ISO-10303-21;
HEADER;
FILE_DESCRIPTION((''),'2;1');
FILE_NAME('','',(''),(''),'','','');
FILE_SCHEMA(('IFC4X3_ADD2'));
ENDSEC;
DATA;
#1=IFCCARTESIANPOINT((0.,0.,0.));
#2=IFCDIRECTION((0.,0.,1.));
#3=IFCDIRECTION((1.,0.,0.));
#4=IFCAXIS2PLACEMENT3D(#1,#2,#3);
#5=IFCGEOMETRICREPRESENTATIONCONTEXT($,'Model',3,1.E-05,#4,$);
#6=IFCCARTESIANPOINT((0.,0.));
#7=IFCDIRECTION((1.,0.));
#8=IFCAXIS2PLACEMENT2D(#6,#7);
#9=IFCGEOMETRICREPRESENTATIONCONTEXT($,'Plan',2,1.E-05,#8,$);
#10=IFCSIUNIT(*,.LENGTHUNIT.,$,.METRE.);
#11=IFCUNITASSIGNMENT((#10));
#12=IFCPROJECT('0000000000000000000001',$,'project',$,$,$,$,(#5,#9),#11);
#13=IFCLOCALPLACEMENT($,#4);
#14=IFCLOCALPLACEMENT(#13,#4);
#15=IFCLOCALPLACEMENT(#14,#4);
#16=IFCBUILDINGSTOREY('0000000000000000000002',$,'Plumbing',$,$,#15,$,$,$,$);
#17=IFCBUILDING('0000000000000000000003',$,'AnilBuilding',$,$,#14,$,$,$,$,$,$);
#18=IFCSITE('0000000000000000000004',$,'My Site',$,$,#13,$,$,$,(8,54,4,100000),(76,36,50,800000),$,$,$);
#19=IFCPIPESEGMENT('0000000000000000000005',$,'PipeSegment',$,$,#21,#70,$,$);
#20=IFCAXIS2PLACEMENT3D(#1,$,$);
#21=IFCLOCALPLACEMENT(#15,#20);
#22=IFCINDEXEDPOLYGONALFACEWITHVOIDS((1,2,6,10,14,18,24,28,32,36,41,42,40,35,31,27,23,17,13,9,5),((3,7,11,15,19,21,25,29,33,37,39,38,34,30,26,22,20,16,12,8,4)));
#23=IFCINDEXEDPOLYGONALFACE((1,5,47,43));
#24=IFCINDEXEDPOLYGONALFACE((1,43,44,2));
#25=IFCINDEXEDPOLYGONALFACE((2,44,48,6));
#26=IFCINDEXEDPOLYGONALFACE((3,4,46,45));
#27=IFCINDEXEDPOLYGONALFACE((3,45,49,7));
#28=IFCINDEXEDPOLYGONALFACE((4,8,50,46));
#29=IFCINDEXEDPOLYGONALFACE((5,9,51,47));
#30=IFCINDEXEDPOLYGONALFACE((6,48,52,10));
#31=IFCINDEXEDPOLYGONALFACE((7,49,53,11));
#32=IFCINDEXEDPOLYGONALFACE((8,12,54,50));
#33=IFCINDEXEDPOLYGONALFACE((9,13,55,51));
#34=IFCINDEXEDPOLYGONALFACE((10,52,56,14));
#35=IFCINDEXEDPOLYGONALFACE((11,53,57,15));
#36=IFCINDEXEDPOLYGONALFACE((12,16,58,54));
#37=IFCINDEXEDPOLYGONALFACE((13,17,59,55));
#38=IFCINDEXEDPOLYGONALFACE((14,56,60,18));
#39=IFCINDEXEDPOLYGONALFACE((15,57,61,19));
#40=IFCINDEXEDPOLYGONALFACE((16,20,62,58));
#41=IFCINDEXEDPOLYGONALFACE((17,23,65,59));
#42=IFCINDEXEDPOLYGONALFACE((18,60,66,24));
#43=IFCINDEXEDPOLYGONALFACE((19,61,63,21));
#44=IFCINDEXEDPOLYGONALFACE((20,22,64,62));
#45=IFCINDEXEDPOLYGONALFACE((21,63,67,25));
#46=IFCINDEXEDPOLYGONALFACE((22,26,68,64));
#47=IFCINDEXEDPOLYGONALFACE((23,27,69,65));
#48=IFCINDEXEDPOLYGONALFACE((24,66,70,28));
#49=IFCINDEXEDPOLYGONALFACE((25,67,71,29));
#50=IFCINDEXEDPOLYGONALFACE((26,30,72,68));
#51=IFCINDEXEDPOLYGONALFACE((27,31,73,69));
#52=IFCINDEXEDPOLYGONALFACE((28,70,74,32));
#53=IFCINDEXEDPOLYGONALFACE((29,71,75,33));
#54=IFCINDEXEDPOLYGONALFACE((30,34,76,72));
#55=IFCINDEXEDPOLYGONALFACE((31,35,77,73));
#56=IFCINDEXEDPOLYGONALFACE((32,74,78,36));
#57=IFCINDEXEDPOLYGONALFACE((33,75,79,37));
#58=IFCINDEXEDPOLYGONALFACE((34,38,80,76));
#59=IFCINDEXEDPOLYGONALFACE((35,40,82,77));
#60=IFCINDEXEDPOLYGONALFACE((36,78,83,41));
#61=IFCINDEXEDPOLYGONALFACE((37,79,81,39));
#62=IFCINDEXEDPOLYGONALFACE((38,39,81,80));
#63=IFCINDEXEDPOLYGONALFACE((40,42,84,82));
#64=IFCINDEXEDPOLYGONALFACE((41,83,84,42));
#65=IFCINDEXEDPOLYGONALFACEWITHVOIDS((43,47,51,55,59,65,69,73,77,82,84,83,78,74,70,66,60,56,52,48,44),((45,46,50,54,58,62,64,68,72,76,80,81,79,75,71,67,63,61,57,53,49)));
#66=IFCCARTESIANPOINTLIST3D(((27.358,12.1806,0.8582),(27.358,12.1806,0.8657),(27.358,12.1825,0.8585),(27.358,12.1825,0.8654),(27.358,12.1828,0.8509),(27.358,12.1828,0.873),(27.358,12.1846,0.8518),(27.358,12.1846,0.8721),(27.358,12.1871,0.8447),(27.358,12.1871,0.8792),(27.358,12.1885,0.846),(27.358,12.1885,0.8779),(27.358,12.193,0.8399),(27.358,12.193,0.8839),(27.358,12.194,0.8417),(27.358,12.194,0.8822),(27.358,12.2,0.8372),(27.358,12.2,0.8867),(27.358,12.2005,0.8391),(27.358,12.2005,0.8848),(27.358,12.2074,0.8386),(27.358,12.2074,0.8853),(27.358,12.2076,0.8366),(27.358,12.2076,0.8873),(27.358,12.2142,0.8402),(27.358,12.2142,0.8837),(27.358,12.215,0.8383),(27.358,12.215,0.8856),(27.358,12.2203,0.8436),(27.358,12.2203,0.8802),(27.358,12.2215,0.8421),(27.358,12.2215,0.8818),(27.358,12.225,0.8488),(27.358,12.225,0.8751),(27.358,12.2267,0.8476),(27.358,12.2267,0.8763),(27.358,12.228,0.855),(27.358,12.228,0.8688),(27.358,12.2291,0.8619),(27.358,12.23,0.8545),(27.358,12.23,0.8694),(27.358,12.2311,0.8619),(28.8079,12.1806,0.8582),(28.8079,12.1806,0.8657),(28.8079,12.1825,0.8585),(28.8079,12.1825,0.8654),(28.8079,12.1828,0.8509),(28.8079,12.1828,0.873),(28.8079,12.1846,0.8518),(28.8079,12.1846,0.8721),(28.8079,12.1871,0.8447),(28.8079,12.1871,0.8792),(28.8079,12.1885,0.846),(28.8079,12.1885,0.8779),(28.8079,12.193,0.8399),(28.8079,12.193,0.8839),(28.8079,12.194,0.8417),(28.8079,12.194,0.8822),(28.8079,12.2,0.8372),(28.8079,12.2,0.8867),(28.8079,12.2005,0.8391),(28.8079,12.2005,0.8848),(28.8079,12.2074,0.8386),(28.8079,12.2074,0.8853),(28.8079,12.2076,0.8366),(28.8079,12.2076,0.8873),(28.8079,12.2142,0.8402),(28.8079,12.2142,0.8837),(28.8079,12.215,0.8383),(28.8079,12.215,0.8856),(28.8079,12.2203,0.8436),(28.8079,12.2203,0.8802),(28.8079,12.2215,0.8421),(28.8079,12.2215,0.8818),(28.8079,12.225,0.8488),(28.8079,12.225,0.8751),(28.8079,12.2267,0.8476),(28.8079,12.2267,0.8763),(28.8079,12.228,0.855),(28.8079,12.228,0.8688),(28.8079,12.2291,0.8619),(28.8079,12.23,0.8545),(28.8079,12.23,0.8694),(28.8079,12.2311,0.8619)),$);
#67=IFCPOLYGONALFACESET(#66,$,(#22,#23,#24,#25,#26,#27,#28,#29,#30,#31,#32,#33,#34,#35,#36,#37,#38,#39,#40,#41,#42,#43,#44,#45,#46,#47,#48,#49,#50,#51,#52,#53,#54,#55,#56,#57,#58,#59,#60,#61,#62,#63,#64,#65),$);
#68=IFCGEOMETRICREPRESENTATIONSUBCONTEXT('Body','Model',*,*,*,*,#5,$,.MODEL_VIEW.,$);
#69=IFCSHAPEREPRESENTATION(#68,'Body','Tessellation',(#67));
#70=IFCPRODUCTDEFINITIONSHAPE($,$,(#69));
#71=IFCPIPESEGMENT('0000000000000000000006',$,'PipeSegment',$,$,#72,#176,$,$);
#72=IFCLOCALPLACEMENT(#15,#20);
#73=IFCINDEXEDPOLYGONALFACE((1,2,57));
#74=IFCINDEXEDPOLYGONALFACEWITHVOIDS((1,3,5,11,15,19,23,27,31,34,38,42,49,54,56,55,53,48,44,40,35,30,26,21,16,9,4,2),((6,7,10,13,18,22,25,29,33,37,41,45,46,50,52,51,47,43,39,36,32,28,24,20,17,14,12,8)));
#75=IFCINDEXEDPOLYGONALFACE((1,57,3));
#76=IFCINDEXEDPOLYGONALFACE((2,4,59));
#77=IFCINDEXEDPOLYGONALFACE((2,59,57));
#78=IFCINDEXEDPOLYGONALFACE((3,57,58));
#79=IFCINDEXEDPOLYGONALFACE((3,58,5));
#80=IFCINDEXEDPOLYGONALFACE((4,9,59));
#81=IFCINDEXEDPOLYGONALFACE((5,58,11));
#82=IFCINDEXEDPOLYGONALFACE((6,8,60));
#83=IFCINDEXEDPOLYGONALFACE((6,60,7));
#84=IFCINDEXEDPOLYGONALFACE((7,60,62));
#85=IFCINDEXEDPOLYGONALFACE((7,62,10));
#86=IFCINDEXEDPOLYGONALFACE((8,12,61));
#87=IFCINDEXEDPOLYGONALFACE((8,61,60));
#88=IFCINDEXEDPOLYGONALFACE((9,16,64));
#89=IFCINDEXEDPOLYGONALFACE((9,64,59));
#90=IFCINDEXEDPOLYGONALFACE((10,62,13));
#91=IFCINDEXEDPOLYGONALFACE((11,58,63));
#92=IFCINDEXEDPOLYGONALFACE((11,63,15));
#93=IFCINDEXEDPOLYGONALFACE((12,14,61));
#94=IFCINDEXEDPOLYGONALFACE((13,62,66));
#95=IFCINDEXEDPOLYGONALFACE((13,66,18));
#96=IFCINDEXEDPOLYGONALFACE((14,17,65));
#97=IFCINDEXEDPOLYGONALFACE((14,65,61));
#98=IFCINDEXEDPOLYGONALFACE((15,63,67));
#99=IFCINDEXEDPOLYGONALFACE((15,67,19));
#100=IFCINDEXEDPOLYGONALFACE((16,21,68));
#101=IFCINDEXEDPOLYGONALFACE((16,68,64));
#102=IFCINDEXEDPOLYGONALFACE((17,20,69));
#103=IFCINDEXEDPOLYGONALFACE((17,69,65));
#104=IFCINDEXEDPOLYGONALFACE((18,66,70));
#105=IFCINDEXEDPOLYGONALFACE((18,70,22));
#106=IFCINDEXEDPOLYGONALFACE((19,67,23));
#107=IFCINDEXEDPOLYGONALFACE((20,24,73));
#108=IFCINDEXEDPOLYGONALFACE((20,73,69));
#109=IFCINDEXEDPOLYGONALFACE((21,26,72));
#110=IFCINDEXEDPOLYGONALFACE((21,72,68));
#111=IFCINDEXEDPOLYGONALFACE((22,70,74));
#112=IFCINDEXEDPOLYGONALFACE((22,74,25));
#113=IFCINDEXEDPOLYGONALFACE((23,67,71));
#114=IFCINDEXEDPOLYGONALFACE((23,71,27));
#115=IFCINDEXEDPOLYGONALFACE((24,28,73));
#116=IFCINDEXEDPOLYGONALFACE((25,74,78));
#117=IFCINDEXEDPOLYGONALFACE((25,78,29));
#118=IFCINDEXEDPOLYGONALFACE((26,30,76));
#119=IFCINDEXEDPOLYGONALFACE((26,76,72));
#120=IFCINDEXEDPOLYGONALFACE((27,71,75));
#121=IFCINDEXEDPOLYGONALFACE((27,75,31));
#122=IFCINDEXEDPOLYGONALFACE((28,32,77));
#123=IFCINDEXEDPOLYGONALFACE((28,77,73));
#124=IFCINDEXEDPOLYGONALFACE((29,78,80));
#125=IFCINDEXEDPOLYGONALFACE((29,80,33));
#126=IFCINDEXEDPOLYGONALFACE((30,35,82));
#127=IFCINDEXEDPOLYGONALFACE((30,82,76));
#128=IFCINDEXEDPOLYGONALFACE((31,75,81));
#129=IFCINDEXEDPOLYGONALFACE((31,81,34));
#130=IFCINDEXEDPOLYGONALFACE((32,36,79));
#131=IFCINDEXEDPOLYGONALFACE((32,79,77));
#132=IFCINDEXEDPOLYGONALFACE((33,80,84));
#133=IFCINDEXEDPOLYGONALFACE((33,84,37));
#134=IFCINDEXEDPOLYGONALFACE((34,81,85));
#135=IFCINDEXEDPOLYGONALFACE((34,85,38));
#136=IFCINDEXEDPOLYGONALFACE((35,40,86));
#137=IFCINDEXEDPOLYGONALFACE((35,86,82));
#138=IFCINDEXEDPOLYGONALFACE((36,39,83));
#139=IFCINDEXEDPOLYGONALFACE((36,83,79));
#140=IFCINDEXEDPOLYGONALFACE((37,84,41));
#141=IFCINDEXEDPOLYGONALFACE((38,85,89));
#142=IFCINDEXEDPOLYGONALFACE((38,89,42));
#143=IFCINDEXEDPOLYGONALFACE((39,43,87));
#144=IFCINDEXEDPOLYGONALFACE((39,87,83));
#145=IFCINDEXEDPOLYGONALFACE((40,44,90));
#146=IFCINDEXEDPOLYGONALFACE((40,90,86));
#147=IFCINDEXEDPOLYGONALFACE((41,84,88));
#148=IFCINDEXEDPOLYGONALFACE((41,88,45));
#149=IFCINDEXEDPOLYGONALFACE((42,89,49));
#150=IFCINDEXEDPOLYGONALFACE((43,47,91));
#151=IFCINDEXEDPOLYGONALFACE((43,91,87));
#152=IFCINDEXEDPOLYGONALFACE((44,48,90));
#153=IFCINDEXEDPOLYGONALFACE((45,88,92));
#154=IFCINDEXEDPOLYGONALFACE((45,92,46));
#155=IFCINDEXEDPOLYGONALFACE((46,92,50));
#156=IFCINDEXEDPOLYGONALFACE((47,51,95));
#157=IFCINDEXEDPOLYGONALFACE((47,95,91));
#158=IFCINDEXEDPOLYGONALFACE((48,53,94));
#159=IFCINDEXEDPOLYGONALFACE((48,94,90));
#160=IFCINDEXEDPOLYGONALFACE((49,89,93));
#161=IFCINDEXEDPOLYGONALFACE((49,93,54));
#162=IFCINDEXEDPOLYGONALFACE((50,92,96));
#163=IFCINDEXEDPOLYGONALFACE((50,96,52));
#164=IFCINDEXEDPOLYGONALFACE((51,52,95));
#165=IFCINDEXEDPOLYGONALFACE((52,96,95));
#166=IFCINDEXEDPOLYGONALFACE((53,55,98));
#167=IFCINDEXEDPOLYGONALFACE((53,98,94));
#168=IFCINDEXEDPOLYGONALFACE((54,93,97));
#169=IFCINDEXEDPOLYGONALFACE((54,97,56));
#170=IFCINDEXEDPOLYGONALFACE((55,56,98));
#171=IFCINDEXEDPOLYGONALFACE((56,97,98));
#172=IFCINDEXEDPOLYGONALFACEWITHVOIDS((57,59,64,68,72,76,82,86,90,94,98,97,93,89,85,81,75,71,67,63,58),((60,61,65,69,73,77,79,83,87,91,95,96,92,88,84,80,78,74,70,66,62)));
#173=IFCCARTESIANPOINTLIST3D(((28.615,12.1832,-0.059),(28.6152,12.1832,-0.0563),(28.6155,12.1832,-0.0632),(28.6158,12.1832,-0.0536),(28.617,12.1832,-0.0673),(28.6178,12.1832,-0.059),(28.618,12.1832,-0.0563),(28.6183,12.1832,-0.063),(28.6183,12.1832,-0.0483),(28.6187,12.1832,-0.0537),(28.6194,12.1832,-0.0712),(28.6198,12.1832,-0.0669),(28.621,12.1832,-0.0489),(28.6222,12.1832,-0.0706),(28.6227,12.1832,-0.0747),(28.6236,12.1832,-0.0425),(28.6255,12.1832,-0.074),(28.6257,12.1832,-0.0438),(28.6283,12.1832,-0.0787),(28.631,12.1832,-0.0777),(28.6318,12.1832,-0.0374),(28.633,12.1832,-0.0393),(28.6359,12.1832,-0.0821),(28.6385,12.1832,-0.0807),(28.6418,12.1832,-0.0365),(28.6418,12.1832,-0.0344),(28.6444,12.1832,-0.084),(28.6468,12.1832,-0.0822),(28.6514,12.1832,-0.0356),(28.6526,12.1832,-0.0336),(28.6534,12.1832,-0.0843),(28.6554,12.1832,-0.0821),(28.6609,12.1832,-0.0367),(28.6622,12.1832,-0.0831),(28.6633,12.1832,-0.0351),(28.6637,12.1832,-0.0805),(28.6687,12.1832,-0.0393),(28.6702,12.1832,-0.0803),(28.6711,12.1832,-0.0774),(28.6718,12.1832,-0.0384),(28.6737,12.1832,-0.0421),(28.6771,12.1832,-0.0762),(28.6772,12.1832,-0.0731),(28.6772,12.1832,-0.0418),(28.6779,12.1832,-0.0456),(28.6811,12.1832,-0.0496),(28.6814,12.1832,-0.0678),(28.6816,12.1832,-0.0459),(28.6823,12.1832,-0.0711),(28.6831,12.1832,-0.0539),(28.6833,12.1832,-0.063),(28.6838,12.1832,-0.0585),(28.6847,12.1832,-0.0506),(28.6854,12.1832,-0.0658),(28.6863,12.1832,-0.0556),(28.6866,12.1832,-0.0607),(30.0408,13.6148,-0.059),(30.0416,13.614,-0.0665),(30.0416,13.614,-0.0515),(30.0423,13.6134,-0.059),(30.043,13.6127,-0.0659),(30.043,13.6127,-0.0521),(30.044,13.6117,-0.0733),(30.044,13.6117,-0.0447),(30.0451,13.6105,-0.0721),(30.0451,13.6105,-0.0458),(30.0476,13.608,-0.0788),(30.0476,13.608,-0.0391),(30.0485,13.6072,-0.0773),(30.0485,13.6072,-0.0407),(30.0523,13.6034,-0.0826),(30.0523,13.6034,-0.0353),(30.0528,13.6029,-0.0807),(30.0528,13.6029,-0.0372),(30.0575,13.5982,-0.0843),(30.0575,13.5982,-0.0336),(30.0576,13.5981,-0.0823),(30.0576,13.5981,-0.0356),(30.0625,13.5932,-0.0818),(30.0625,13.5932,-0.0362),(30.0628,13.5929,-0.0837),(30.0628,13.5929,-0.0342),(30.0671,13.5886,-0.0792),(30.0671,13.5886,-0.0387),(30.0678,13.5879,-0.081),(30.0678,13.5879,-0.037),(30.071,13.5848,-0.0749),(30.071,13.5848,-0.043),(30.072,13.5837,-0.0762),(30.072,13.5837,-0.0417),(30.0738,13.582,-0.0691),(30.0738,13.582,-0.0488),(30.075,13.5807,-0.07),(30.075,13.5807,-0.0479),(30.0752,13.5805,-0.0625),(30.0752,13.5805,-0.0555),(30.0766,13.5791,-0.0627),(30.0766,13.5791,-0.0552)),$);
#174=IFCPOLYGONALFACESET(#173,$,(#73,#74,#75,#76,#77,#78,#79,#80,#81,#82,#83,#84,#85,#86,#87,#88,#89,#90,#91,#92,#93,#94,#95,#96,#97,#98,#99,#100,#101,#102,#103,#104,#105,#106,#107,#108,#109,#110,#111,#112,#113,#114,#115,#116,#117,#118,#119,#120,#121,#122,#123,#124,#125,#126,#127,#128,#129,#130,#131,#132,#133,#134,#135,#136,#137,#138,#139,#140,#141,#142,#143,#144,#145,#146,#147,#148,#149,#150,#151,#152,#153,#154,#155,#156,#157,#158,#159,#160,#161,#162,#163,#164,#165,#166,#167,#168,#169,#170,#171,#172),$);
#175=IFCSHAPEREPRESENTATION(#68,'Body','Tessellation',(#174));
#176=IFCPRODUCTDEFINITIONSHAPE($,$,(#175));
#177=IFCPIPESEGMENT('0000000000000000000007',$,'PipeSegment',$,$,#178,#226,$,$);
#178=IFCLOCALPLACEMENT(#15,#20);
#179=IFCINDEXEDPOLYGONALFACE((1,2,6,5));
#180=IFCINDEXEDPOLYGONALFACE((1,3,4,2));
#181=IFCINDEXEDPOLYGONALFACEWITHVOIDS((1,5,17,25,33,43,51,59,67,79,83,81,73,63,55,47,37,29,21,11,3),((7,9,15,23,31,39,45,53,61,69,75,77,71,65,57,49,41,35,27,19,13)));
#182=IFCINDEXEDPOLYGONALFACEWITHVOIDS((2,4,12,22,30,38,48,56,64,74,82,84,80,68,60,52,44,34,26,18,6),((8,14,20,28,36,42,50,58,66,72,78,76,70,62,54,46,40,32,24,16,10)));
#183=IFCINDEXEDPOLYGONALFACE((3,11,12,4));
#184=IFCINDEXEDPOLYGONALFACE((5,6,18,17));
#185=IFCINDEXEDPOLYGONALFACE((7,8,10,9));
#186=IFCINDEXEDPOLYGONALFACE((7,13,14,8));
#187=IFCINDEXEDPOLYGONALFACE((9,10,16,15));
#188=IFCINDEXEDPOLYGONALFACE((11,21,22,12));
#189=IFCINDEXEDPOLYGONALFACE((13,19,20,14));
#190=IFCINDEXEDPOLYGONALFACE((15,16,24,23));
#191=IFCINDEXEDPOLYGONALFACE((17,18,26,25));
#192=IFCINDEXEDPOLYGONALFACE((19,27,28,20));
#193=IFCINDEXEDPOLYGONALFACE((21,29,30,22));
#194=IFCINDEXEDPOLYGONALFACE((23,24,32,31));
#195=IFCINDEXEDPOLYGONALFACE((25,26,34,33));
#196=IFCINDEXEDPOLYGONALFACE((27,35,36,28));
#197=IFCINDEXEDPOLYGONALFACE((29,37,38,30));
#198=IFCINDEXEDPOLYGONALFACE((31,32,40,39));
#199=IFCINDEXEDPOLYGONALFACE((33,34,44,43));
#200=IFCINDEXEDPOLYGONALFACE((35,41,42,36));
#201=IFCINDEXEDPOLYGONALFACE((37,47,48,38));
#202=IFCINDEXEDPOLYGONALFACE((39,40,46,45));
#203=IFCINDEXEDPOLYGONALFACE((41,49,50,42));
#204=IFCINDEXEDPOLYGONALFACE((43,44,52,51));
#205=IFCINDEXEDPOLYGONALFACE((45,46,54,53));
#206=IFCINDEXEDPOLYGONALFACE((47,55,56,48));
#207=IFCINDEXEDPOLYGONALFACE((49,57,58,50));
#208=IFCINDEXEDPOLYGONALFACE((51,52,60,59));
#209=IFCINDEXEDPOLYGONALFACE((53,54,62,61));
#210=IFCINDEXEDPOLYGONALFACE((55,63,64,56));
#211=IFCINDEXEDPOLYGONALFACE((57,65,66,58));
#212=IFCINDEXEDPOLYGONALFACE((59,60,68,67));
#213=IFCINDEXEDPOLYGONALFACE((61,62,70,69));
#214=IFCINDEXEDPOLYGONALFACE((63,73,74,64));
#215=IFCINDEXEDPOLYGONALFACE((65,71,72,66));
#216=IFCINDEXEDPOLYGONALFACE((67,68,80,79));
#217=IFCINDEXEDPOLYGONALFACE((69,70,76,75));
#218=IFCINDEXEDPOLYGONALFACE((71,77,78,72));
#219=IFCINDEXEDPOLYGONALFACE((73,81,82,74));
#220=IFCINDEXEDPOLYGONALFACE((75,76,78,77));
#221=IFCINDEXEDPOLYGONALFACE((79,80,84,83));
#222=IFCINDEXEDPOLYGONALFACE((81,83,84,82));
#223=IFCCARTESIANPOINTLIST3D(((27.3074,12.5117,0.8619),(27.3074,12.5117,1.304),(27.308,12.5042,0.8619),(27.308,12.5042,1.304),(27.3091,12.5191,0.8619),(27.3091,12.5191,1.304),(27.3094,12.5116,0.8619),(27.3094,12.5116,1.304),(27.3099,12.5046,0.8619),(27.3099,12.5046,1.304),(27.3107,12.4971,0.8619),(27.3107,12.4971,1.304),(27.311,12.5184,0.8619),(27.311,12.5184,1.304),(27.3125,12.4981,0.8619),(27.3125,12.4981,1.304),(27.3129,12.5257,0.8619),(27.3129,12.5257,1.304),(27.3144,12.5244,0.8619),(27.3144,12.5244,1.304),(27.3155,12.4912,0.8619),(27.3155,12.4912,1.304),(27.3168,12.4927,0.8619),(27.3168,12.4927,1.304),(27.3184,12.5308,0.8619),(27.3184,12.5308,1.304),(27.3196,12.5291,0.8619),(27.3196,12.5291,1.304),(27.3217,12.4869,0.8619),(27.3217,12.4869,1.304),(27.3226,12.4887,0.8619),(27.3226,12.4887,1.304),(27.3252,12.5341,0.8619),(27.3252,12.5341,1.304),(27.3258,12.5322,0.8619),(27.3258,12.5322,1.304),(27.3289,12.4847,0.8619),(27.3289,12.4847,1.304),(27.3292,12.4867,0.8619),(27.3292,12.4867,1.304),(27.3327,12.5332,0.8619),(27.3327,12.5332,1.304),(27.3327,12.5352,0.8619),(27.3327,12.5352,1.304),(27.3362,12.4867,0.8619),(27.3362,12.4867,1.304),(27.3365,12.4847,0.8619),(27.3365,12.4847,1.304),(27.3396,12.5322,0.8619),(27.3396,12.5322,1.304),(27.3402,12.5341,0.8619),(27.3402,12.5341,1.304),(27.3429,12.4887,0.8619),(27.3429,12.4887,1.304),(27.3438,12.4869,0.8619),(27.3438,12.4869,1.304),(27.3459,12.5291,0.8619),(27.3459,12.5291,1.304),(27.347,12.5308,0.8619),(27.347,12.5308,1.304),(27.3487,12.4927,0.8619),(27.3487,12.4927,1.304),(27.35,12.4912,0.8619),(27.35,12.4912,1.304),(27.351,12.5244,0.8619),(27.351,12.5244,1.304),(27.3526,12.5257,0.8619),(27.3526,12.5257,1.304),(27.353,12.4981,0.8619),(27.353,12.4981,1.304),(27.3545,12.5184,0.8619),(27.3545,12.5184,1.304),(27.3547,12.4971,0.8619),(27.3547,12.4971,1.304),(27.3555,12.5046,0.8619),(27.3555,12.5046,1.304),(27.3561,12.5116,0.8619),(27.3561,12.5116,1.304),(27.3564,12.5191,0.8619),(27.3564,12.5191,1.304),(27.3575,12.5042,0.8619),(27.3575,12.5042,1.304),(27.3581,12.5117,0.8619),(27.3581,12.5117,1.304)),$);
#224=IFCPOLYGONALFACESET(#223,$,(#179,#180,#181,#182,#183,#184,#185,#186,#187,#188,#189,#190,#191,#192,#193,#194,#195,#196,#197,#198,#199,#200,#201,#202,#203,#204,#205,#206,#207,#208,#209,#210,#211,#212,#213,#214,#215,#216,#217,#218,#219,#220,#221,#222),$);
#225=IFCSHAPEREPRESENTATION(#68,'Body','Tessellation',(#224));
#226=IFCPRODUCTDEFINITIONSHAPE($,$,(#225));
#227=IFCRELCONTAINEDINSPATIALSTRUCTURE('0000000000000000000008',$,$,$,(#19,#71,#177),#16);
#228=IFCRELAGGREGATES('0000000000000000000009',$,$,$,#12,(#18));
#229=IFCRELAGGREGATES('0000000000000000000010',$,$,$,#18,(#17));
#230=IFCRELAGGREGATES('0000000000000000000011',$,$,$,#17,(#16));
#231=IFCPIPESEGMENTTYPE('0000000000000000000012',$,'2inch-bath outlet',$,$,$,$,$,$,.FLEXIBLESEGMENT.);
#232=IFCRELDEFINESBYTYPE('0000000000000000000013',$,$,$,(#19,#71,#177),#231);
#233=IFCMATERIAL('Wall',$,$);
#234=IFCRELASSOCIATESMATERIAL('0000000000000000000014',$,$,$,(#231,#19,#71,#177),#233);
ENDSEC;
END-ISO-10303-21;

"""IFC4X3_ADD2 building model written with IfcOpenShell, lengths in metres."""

from ifc_helpers import new_model, si_unit, frame, origin_with_axes, origin_2d_with_axis, place, context, subcontext, project, spatial, hollow_circle, extrude, clip, halfspace, material, material_profile, profile_set, profile_usage, type_object, element, save


model = new_model("IFC4X3_ADD2")

# Units and contexts
model_context = context("Model", 3, precision=1e-05, world=origin_with_axes())
plan_context = context("Plan", 2, precision=1e-05, world=origin_2d_with_axis())
body_context = subcontext(model_context, "Body", "Model", "MODEL_VIEW")
ifc_project = project(units=[si_unit("LENGTHUNIT", "METRE")], contexts=[model_context, plan_context])

# Site, building, storey
site_placement = place(None, origin_with_axes())
site = spatial("IfcSite", under=ifc_project, at=site_placement, Name="My Site", RefLatitude=(8, 54, 4, 100000), RefLongitude=(76, 36, 50, 800000))
building_placement = place(site_placement, origin_with_axes())
building = spatial("IfcBuilding", under=site, at=building_placement, Name="AnilBuilding")
storey_placement = place(building_placement, origin_with_axes())
storey = spatial("IfcBuildingStorey", under=building, at=storey_placement, Name="Plumbing")

# Pipe segments
ifc_material_1 = material(Name="Wall")
ifc_material_profile_1 = material_profile(ifc_material_1, hollow_circle(Radius=0.0254, WallThickness=0.002))
ifc_profile_set_1 = profile_set([ifc_material_profile_1], Name="graywater")
pipe_segment_type_1 = type_object("IfcPipeSegmentType", Name="2inch-bath outlet", PredefinedType="FLEXIBLESEGMENT", material=ifc_profile_set_1)
ifc_profile_usage_1 = profile_usage(ifc_profile_set_1, cardinal=5)
pipe_segment_1_placement = place(storey_placement, frame((27.358, 12.2057, 0.8619), z_axis=(1.0, 0.0, 0.0), x_axis=(0.0, 1.0, 0.0)))
element("IfcPipeSegment", 1, at=pipe_segment_1_placement, inside=storey, type_object=pipe_segment_type_1, material=ifc_profile_usage_1, Name="PipeSegment", context=body_context, shape_type="SweptSolid", body=[
    extrude(hollow_circle(Radius=0.0254, WallThickness=0.002), origin_with_axes(), (0.0, 0.0, 1.0), 1.4499),
])
ifc_profile_usage_2 = profile_usage(ifc_profile_set_1, cardinal=5)
pipe_segment_2_placement = place(storey_placement, frame((28.615, 12.1472, -0.059), z_axis=(0.705686, 0.708524, 0.0), x_axis=(-0.708524, 0.705686, 0.0)))
element("IfcPipeSegment", 2, at=pipe_segment_2_placement, inside=storey, type_object=pipe_segment_type_1, material=ifc_profile_usage_2, Name="PipeSegment", context=body_context, shape_type="Clipping", body=[
    clip(extrude(hollow_circle(Radius=0.0254, WallThickness=0.002), origin_with_axes(), (0.0, 0.0, 1.0), 2.046), halfspace(frame((-0.1292, 0.0254, 0.1794), z_axis=(-0.705686, 0.0, -0.708525), x_axis=(0.0, 1.0, 0.0)), False)),
])
ifc_profile_usage_3 = profile_usage(ifc_profile_set_1, cardinal=5)
pipe_segment_3_placement = place(storey_placement, frame((27.3327, 12.5098, 0.8619), z_axis=(0.0, 0.0, 1.0), x_axis=(0.0, 1.0, 0.0)))
element("IfcPipeSegment", 3, at=pipe_segment_3_placement, inside=storey, type_object=pipe_segment_type_1, material=ifc_profile_usage_3, Name="PipeSegment", context=body_context, shape_type="SweptSolid", body=[
    extrude(hollow_circle(Radius=0.0254, WallThickness=0.002), origin_with_axes(), (0.0, 0.0, 1.0), 0.4421),
])

save(model, "model.ifc")
